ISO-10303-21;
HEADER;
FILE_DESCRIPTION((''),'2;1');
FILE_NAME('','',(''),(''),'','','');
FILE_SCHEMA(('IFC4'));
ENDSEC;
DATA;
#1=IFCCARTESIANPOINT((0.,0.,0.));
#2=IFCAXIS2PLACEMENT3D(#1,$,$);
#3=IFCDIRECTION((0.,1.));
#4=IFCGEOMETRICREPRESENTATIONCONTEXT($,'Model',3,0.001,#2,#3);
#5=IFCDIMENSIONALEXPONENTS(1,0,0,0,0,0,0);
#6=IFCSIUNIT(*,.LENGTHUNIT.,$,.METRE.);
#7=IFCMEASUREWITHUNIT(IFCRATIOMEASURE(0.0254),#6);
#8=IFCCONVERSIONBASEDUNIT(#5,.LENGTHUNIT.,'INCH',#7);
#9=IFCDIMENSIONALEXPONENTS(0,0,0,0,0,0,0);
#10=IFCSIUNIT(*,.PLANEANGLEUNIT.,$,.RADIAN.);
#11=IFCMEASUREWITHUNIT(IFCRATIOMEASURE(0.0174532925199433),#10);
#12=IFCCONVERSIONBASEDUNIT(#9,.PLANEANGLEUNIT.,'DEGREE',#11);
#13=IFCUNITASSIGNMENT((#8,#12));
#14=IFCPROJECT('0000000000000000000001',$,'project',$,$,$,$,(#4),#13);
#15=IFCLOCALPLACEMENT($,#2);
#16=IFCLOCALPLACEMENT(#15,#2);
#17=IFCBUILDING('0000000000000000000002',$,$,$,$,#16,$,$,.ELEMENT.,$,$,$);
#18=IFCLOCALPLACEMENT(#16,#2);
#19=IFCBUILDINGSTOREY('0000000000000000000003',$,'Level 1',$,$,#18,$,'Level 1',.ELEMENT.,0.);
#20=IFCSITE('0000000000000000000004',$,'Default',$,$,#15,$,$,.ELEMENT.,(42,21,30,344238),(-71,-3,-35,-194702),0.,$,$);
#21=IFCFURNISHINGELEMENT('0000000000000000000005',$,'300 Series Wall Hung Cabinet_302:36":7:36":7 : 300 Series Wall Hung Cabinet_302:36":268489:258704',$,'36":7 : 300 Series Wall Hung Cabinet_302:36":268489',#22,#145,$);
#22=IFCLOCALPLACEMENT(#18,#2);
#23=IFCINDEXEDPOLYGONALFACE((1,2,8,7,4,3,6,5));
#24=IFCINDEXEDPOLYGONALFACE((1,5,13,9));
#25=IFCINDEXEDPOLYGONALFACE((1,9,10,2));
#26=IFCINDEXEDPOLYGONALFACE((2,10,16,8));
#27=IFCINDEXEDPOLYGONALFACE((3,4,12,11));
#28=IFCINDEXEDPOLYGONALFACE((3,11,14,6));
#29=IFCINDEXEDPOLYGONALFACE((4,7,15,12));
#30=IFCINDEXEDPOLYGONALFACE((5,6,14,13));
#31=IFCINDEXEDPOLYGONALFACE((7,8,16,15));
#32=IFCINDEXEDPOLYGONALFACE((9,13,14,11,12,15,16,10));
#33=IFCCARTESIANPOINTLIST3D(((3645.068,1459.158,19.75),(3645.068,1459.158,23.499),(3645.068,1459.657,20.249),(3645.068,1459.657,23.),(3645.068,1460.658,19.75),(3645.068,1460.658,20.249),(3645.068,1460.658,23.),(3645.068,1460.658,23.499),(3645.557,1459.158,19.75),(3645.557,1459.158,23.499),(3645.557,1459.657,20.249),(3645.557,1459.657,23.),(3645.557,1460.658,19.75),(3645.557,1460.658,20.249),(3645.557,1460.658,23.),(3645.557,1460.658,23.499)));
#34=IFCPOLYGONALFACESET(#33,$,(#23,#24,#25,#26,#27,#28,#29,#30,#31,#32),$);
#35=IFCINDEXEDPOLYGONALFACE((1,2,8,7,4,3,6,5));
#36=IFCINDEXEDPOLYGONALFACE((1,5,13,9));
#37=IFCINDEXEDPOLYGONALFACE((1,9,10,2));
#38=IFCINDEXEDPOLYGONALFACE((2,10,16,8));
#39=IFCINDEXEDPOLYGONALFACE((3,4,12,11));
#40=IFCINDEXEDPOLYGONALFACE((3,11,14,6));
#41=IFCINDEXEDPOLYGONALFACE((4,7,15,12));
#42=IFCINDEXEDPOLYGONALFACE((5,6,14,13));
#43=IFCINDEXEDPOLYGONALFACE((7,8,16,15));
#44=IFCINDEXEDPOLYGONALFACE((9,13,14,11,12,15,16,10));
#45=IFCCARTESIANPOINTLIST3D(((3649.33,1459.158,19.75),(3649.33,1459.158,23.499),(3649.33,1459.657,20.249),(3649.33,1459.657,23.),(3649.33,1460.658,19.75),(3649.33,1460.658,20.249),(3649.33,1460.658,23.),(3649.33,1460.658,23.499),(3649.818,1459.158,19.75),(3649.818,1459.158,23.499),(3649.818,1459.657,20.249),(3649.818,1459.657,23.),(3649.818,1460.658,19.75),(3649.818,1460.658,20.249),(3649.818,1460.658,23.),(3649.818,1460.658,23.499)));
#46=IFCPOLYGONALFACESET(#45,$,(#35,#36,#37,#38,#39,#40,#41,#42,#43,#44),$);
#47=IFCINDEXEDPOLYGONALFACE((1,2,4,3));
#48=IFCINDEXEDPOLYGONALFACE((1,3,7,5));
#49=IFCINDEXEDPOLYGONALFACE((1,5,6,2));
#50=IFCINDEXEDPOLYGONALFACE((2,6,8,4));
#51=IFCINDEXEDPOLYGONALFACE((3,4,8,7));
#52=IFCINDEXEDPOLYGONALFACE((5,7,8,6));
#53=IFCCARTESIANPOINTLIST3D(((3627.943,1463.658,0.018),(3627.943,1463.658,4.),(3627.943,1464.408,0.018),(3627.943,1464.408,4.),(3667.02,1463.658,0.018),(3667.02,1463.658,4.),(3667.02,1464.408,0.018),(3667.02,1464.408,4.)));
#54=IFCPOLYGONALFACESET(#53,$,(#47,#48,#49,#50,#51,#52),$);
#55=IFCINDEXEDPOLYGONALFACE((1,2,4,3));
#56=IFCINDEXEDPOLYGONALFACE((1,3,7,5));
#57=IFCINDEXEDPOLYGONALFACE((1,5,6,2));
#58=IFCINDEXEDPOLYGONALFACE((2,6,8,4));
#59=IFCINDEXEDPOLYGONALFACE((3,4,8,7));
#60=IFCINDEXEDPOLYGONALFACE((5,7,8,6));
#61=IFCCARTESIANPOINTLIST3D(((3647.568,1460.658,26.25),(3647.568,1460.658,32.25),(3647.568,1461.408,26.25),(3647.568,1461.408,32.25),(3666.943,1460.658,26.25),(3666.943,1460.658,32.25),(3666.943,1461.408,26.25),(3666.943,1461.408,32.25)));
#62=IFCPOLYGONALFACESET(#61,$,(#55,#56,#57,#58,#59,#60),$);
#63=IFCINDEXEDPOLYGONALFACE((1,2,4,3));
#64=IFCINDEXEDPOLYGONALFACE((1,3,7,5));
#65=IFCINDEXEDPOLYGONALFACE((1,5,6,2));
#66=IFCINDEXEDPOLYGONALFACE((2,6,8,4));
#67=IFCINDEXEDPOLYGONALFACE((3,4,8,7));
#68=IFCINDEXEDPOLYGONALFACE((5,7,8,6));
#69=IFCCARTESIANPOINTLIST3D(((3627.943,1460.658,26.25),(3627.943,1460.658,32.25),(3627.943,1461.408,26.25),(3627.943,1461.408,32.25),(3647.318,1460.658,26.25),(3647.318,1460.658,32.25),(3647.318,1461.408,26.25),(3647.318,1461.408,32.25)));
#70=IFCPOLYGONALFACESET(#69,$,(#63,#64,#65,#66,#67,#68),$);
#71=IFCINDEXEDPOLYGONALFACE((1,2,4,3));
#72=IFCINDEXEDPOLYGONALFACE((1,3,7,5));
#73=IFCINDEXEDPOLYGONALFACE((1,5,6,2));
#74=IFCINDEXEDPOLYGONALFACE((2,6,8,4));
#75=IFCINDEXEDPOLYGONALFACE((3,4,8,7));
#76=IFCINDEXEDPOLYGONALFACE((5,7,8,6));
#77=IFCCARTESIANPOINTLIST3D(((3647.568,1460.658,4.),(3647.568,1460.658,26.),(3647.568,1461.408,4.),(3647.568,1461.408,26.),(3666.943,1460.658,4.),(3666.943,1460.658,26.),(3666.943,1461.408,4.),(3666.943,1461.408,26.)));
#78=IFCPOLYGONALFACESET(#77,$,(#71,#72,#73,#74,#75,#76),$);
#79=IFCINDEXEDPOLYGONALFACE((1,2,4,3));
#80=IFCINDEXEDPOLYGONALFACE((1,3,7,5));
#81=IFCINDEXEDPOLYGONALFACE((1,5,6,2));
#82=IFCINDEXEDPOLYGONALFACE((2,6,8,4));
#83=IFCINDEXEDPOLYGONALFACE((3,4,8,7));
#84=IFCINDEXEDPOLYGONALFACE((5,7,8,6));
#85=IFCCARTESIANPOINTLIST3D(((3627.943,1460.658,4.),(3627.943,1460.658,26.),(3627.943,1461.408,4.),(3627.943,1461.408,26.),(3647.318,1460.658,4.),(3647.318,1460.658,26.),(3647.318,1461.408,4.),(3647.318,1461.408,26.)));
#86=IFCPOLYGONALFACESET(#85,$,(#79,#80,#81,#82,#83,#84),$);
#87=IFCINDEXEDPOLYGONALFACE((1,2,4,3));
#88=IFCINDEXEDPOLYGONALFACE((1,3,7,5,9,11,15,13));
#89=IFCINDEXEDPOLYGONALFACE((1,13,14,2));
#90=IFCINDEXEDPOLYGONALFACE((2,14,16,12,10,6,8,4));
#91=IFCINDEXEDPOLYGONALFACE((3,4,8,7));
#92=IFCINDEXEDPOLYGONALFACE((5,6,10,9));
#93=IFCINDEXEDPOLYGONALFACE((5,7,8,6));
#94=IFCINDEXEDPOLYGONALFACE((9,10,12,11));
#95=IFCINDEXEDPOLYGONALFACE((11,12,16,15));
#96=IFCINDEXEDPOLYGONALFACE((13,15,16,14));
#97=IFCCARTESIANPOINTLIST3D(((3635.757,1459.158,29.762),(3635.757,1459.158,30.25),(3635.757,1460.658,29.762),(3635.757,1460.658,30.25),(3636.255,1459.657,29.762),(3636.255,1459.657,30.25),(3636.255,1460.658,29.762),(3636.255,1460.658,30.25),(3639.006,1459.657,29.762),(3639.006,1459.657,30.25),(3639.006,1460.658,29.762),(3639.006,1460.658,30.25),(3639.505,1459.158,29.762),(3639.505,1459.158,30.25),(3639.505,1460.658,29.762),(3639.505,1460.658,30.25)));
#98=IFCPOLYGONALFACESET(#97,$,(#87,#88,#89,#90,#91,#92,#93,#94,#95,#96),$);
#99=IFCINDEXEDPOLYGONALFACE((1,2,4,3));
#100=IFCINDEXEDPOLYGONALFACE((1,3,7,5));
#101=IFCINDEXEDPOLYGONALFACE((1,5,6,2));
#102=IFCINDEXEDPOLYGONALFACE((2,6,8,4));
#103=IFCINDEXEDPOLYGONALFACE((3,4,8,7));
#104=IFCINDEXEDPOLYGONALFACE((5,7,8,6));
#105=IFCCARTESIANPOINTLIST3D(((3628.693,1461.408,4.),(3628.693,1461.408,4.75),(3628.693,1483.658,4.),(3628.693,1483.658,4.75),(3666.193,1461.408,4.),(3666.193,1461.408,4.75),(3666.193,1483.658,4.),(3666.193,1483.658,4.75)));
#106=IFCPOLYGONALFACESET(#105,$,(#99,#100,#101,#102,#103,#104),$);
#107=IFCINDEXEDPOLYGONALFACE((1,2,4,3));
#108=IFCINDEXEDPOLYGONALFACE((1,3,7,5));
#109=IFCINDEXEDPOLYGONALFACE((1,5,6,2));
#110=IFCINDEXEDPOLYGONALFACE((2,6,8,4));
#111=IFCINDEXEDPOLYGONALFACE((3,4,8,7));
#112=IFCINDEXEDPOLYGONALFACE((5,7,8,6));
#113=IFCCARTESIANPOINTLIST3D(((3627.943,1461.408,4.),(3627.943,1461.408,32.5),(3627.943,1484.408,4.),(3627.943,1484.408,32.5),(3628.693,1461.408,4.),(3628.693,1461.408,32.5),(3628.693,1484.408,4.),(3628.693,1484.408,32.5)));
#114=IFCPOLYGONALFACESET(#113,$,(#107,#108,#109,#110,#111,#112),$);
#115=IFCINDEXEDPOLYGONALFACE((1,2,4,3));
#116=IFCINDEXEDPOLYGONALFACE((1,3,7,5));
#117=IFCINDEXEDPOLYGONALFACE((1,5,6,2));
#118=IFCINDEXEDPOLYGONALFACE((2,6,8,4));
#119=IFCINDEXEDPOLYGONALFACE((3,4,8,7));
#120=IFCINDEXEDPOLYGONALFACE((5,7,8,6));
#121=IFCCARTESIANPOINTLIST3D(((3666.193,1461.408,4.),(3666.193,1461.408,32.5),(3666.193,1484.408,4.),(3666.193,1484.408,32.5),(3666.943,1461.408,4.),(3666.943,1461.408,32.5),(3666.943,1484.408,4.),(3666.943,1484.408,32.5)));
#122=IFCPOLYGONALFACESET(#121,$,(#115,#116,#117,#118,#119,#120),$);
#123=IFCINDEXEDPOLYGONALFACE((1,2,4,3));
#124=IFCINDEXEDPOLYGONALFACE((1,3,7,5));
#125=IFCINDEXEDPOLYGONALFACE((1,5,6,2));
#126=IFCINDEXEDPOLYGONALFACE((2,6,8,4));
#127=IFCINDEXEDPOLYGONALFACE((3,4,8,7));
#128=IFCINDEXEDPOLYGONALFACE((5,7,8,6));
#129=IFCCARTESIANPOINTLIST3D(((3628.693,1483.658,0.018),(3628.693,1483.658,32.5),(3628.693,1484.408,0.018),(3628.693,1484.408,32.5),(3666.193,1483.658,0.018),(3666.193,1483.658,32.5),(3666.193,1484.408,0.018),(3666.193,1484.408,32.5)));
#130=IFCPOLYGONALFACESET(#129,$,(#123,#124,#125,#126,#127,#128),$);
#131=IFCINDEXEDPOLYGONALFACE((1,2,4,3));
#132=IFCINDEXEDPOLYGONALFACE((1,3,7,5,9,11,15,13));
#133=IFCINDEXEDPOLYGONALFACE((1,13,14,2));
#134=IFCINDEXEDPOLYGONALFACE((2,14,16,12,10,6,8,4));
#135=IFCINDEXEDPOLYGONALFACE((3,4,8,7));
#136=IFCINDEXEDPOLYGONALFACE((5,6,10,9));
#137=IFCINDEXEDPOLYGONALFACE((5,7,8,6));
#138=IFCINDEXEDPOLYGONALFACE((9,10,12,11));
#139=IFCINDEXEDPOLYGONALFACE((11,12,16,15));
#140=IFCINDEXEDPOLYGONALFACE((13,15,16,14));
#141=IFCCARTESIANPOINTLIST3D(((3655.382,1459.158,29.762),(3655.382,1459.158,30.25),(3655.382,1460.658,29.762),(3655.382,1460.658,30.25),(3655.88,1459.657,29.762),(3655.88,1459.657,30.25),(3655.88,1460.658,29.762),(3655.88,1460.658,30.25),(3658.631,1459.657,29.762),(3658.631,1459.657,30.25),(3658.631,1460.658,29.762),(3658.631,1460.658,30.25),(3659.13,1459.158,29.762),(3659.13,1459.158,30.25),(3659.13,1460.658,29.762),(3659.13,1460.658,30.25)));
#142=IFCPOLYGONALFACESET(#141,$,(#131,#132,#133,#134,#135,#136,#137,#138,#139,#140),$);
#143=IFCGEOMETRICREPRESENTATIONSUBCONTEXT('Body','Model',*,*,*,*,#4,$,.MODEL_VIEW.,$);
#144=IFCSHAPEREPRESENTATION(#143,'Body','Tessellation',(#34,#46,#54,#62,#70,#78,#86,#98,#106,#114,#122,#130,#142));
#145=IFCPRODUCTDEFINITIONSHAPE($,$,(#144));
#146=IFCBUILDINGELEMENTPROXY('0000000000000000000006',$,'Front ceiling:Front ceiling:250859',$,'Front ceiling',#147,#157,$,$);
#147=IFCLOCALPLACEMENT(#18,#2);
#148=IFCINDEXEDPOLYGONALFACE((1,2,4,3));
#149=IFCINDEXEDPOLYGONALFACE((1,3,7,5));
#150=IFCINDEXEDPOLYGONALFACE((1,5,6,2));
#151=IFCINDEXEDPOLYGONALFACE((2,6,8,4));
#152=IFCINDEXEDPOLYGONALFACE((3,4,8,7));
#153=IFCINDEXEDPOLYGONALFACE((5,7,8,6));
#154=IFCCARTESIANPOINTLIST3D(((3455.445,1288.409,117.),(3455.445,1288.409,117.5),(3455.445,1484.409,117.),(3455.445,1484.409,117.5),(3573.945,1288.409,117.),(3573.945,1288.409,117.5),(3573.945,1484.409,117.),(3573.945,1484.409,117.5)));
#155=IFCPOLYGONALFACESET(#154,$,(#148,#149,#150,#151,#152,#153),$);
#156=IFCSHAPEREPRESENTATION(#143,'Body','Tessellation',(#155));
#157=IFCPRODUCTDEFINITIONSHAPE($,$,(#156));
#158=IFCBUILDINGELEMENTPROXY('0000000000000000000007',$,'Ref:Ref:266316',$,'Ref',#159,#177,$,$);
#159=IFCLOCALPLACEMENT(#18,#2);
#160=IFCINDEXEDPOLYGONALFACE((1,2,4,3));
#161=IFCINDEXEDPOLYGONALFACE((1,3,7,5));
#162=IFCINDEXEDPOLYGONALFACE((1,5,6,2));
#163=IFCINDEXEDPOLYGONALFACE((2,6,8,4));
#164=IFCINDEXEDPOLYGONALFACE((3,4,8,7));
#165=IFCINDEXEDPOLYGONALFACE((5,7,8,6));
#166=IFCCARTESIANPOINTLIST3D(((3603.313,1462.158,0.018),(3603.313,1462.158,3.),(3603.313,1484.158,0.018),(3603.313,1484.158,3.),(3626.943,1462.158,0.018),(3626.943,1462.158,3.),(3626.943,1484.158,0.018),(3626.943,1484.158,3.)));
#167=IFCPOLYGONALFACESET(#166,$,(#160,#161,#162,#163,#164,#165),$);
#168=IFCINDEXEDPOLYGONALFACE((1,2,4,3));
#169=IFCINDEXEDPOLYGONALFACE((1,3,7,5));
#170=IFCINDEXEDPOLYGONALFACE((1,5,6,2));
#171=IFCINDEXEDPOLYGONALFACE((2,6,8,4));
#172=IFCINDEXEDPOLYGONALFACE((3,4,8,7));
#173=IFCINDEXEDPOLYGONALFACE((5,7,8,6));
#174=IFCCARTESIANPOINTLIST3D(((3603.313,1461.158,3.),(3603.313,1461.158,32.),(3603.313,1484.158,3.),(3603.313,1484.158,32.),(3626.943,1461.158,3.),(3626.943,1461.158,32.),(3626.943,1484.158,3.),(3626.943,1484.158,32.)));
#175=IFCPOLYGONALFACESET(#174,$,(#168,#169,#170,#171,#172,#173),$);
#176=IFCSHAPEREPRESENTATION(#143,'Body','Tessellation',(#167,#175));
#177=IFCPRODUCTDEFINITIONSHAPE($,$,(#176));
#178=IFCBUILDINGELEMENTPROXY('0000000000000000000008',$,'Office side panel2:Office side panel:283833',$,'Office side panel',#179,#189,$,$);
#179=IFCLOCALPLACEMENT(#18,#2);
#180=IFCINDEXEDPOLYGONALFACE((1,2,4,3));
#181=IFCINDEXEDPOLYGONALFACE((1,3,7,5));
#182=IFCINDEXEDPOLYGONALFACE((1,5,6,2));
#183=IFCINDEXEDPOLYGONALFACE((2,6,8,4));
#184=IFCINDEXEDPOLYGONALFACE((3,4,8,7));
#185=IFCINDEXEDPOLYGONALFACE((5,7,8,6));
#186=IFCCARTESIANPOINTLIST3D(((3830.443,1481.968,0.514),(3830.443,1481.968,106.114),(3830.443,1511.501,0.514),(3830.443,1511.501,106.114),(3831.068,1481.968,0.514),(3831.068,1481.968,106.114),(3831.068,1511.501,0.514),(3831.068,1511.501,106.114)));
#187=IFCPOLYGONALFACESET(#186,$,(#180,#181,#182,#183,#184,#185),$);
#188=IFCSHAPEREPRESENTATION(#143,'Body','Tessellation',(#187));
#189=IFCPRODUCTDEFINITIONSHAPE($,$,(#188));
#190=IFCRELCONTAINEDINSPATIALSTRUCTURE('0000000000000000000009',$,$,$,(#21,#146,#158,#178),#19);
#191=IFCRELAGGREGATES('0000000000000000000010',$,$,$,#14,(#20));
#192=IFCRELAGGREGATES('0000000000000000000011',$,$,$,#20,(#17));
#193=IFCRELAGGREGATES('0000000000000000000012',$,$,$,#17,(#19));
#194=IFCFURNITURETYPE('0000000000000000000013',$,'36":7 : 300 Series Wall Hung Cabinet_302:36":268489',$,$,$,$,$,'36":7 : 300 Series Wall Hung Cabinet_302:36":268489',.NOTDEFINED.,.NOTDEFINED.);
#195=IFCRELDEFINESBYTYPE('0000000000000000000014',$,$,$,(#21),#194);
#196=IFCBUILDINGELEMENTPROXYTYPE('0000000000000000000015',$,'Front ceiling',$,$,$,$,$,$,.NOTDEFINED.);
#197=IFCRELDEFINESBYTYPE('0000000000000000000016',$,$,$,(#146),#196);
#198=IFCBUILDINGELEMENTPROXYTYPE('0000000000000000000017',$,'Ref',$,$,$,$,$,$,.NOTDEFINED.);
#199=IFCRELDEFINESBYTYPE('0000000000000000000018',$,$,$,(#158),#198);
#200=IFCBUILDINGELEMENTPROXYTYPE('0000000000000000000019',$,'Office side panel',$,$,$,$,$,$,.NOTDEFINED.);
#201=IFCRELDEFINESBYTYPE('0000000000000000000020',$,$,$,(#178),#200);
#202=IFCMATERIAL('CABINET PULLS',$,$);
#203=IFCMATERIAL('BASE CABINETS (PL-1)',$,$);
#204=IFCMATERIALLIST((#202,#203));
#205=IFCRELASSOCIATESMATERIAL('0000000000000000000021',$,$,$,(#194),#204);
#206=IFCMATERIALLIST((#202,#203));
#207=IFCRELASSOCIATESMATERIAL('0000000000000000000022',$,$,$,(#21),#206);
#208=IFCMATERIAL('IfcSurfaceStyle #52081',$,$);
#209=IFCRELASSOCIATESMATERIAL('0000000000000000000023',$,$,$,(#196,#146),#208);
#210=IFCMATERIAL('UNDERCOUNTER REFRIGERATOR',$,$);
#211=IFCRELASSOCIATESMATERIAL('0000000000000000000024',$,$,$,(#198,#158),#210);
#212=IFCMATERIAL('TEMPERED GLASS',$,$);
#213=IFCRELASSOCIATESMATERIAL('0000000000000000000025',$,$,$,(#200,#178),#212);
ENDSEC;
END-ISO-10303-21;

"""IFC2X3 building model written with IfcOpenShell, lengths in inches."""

from ifc_helpers import new_model, entity, si_unit, converted_unit, direction, frame, frame_2d, origin, origin_2d_with_axis, place, context, subcontext, project, spatial, polyline, rectangle, outline, extrude, source, transform, mapped, material, material_list, type_object, type_shapes, element, save


model = new_model("IFC2X3")

# Units and contexts
model_context = context("Model", 3, precision=0.001, world=origin(), true_north=direction((0.0, 1.0)))
body_context = subcontext(model_context, "Body", "Model", "MODEL_VIEW")
ifc_project = project(units=[converted_unit("LENGTHUNIT", "INCH", entity("IfcRatioMeasure", 0.0254), si_unit("LENGTHUNIT", "METRE"), dimensions=[1, 0, 0, 0, 0, 0, 0]), converted_unit("PLANEANGLEUNIT", "DEGREE", entity("IfcRatioMeasure", 0.0174532925199433), si_unit("PLANEANGLEUNIT", "RADIAN"), dimensions=[0, 0, 0, 0, 0, 0, 0])], contexts=[model_context])

# Site, building, storey
site_placement = place(None, origin())
site = spatial("IfcSite", under=ifc_project, at=site_placement, Name="Default", CompositionType="ELEMENT", RefLatitude=(42, 21, 30, 344238), RefLongitude=(-71, -3, -35, -194702), RefElevation=0.0)
building_placement = place(site_placement, origin())
building = spatial("IfcBuilding", under=site, at=building_placement, CompositionType="ELEMENT")
storey_placement = place(building_placement, origin())
storey = spatial("IfcBuildingStorey", under=building, at=storey_placement, Name="Level 1", LongName="Level 1", CompositionType="ELEMENT", Elevation=0.0)

# Furnishing element
ifc_material_1 = material(Name="CABINET PULLS")
ifc_material_2 = material(Name="BASE CABINETS (PL-1)")
ifc_material_list_1 = material_list([ifc_material_1, ifc_material_2])
ifc_material_list_2 = material_list([ifc_material_1, ifc_material_2])
furniture_type_1 = type_object("IfcFurnitureType", Name="36\":7 : 300 Series Wall Hung Cabinet_302:36\":268489", ElementType="36\":7 : 300 Series Wall Hung Cabinet_302:36\":268489", AssemblyPlace="NOTDEFINED", material=ifc_material_list_2)
shared_shape_1 = source(origin(), body_context, "Body", "SweptSolid", [
    extrude(outline(polyline([(-1.375, -0.376), (-1.375, 0.625), (-1.874, 0.625), (-1.874, -0.874), (1.874, -0.874), (1.874, 0.625), (1.375, 0.625), (1.375, -0.376), (-1.375, -0.376)])), frame((3645.068, 1460.033, 21.625), z_axis=(-1.0, 0.0, 0.0), x_axis=(0.0, 0.0, 1.0)), (0.0, 0.0, -1.0), 0.488),
    extrude(outline(polyline([(-1.375, -0.376), (-1.375, 0.625), (-1.874, 0.625), (-1.874, -0.874), (1.874, -0.874), (1.874, 0.625), (1.375, 0.625), (1.375, -0.376), (-1.375, -0.376)])), frame((3649.33, 1460.033, 21.625), z_axis=(-1.0, 0.0, 0.0), x_axis=(0.0, 0.0, 1.0)), (0.0, 0.0, -1.0), 0.488),
    extrude(rectangle(XDim=39.077, YDim=0.75, at=origin_2d_with_axis()), frame((3647.482, 1464.033, 0.018)), (0.0, 0.0, 1.0), 3.982),
    extrude(rectangle(XDim=0.75, YDim=19.375, at=origin_2d_with_axis()), frame((3657.256, 1461.033, 26.25), z_axis=(0.0, 0.0, 1.0), x_axis=(0.0, 1.0, 0.0)), (0.0, 0.0, 1.0), 6.0),
    extrude(rectangle(XDim=0.75, YDim=19.375, at=origin_2d_with_axis()), frame((3637.631, 1461.033, 26.25), z_axis=(0.0, 0.0, 1.0), x_axis=(0.0, 1.0, 0.0)), (0.0, 0.0, 1.0), 6.0),
    extrude(rectangle(XDim=0.75, YDim=19.375, at=origin_2d_with_axis()), frame((3657.256, 1461.033, 4.0), z_axis=(0.0, 0.0, 1.0), x_axis=(0.0, 1.0, 0.0)), (0.0, 0.0, 1.0), 22.0),
    extrude(rectangle(XDim=0.75, YDim=19.375, at=frame_2d((0.0, 0.0), x_axis=(1.0, 0.0))), frame((3637.631, 1461.033, 4.0), z_axis=(0.0, 0.0, 1.0), x_axis=(0.0, 1.0, 0.0)), (0.0, 0.0, 1.0), 22.0),
    extrude(outline(polyline([(-1.375, -0.376), (-1.375, 0.625), (-1.874, 0.625), (-1.874, -0.874), (1.874, -0.874), (1.874, 0.625), (1.375, 0.625), (1.375, -0.376), (-1.375, -0.376)])), frame((3637.631, 1460.033, 29.762), z_axis=(0.0, 0.0, -1.0), x_axis=(-1.0, 0.0, 0.0)), (0.0, 0.0, -1.0), 0.488),
    extrude(rectangle(XDim=22.25, YDim=37.5, at=frame_2d((0.0, 0.0), x_axis=(1.0, 0.0))), frame((3647.443, 1472.533, 4.0), z_axis=(0.0, 0.0, 1.0), x_axis=(0.0, 1.0, 0.0)), (0.0, 0.0, 1.0), 0.75),
    extrude(rectangle(XDim=23.0, YDim=0.75, at=frame_2d((0.0, 0.0), x_axis=(1.0, 0.0))), frame((3628.318, 1472.908, 4.0), z_axis=(0.0, 0.0, 1.0), x_axis=(0.0, -1.0, 0.0)), (0.0, 0.0, 1.0), 28.5),
    extrude(rectangle(XDim=23.0, YDim=0.75, at=frame_2d((0.0, 0.0), x_axis=(1.0, 0.0))), frame((3666.568, 1472.908, 4.0), z_axis=(0.0, 0.0, 1.0), x_axis=(0.0, -1.0, 0.0)), (0.0, 0.0, 1.0), 28.5),
    extrude(rectangle(XDim=37.5, YDim=0.75, at=origin_2d_with_axis()), frame((3647.443, 1484.033, 0.018)), (0.0, 0.0, 1.0), 32.482),
    extrude(outline(polyline([(-1.375, -0.376), (-1.375, 0.625), (-1.874, 0.625), (-1.874, -0.874), (1.874, -0.874), (1.874, 0.625), (1.375, 0.625), (1.375, -0.376), (-1.375, -0.376)])), frame((3657.256, 1460.033, 29.762), z_axis=(0.0, 0.0, -1.0), x_axis=(-1.0, 0.0, 0.0)), (0.0, 0.0, -1.0), 0.488),
])
type_shapes(furniture_type_1, [shared_shape_1])
furnishing_1_placement = place(building_placement, origin())
element("IfcFurnishingElement", 1, at=furnishing_1_placement, inside=storey, type_object=furniture_type_1, material=ifc_material_list_1, Name="300 Series Wall Hung Cabinet_302:36\":7:36\":7 : 300 Series Wall Hung Cabinet_302:36\":268489:258704", ObjectType="36\":7 : 300 Series Wall Hung Cabinet_302:36\":268489", context=body_context, shape_type="MappedRepresentation", body=[
    mapped(shared_shape_1, transform((0.0, 0.0, 0.0), scale=1.0)),
])

# Building element proxies
ifc_material_3 = material(Name="IfcSurfaceStyle #52081")
building_element_proxy_type_1 = type_object("IfcBuildingElementProxyType", Name="Front ceiling", PredefinedType="NOTDEFINED", material=ifc_material_3)
shared_shape_2 = source(origin(), body_context, "Body", "SweptSolid", [
    extrude(rectangle(XDim=118.5, YDim=196.0, at=frame_2d((0.0, 0.0), x_axis=(1.0, 0.0))), frame((3514.695, 1386.409, 117.0)), (0.0, 0.0, 1.0), 0.5),
])
type_shapes(building_element_proxy_type_1, [shared_shape_2])
proxy_1_placement = place(building_placement, origin())
element("IfcBuildingElementProxy", 2, at=proxy_1_placement, inside=storey, type_object=building_element_proxy_type_1, material=ifc_material_3, Name="Front ceiling:Front ceiling:250859", ObjectType="Front ceiling", context=body_context, shape_type="MappedRepresentation", body=[
    mapped(shared_shape_2, transform((0.0, 0.0, 0.0), scale=1.0)),
])
ifc_material_4 = material(Name="UNDERCOUNTER REFRIGERATOR")
building_element_proxy_type_2 = type_object("IfcBuildingElementProxyType", Name="Ref", PredefinedType="NOTDEFINED", material=ifc_material_4)
shared_shape_3 = source(origin(), body_context, "Body", "SweptSolid", [
    extrude(rectangle(XDim=22.0, YDim=23.63, at=frame_2d((0.0, 0.0), x_axis=(1.0, 0.0))), frame((3615.128, 1473.158, 0.018), z_axis=(0.0, 0.0, 1.0), x_axis=(0.0, 1.0, 0.0)), (0.0, 0.0, 1.0), 2.982),
    extrude(rectangle(XDim=23.0, YDim=23.63, at=frame_2d((0.0, 0.0), x_axis=(1.0, 0.0))), frame((3615.128, 1472.658, 3.0), z_axis=(0.0, 0.0, 1.0), x_axis=(0.0, 1.0, 0.0)), (0.0, 0.0, 1.0), 29.0),
])
type_shapes(building_element_proxy_type_2, [shared_shape_3])
proxy_2_placement = place(building_placement, origin())
element("IfcBuildingElementProxy", 3, at=proxy_2_placement, inside=storey, type_object=building_element_proxy_type_2, material=ifc_material_4, Name="Ref:Ref:266316", ObjectType="Ref", context=body_context, shape_type="MappedRepresentation", body=[
    mapped(shared_shape_3, transform((0.0, 0.0, 0.0), scale=1.0)),
])
ifc_material_5 = material(Name="TEMPERED GLASS")
building_element_proxy_type_3 = type_object("IfcBuildingElementProxyType", Name="Office side panel", PredefinedType="NOTDEFINED", material=ifc_material_5)
shared_shape_4 = source(origin(), body_context, "Body", "SweptSolid", [
    extrude(rectangle(XDim=0.625, YDim=29.532, at=frame_2d((0.0, 0.0), x_axis=(1.0, 0.0))), frame((3830.756, 1496.734, 0.514)), (0.0, 0.0, 1.0), 105.6),
])
type_shapes(building_element_proxy_type_3, [shared_shape_4])
proxy_3_placement = place(building_placement, origin())
element("IfcBuildingElementProxy", 4, at=proxy_3_placement, inside=storey, type_object=building_element_proxy_type_3, material=ifc_material_5, Name="Office side panel2:Office side panel:283833", ObjectType="Office side panel", context=body_context, shape_type="MappedRepresentation", body=[
    mapped(shared_shape_4, transform((0.0, 0.0, 0.0), scale=1.0)),
])

save(model, "model.ifc")
